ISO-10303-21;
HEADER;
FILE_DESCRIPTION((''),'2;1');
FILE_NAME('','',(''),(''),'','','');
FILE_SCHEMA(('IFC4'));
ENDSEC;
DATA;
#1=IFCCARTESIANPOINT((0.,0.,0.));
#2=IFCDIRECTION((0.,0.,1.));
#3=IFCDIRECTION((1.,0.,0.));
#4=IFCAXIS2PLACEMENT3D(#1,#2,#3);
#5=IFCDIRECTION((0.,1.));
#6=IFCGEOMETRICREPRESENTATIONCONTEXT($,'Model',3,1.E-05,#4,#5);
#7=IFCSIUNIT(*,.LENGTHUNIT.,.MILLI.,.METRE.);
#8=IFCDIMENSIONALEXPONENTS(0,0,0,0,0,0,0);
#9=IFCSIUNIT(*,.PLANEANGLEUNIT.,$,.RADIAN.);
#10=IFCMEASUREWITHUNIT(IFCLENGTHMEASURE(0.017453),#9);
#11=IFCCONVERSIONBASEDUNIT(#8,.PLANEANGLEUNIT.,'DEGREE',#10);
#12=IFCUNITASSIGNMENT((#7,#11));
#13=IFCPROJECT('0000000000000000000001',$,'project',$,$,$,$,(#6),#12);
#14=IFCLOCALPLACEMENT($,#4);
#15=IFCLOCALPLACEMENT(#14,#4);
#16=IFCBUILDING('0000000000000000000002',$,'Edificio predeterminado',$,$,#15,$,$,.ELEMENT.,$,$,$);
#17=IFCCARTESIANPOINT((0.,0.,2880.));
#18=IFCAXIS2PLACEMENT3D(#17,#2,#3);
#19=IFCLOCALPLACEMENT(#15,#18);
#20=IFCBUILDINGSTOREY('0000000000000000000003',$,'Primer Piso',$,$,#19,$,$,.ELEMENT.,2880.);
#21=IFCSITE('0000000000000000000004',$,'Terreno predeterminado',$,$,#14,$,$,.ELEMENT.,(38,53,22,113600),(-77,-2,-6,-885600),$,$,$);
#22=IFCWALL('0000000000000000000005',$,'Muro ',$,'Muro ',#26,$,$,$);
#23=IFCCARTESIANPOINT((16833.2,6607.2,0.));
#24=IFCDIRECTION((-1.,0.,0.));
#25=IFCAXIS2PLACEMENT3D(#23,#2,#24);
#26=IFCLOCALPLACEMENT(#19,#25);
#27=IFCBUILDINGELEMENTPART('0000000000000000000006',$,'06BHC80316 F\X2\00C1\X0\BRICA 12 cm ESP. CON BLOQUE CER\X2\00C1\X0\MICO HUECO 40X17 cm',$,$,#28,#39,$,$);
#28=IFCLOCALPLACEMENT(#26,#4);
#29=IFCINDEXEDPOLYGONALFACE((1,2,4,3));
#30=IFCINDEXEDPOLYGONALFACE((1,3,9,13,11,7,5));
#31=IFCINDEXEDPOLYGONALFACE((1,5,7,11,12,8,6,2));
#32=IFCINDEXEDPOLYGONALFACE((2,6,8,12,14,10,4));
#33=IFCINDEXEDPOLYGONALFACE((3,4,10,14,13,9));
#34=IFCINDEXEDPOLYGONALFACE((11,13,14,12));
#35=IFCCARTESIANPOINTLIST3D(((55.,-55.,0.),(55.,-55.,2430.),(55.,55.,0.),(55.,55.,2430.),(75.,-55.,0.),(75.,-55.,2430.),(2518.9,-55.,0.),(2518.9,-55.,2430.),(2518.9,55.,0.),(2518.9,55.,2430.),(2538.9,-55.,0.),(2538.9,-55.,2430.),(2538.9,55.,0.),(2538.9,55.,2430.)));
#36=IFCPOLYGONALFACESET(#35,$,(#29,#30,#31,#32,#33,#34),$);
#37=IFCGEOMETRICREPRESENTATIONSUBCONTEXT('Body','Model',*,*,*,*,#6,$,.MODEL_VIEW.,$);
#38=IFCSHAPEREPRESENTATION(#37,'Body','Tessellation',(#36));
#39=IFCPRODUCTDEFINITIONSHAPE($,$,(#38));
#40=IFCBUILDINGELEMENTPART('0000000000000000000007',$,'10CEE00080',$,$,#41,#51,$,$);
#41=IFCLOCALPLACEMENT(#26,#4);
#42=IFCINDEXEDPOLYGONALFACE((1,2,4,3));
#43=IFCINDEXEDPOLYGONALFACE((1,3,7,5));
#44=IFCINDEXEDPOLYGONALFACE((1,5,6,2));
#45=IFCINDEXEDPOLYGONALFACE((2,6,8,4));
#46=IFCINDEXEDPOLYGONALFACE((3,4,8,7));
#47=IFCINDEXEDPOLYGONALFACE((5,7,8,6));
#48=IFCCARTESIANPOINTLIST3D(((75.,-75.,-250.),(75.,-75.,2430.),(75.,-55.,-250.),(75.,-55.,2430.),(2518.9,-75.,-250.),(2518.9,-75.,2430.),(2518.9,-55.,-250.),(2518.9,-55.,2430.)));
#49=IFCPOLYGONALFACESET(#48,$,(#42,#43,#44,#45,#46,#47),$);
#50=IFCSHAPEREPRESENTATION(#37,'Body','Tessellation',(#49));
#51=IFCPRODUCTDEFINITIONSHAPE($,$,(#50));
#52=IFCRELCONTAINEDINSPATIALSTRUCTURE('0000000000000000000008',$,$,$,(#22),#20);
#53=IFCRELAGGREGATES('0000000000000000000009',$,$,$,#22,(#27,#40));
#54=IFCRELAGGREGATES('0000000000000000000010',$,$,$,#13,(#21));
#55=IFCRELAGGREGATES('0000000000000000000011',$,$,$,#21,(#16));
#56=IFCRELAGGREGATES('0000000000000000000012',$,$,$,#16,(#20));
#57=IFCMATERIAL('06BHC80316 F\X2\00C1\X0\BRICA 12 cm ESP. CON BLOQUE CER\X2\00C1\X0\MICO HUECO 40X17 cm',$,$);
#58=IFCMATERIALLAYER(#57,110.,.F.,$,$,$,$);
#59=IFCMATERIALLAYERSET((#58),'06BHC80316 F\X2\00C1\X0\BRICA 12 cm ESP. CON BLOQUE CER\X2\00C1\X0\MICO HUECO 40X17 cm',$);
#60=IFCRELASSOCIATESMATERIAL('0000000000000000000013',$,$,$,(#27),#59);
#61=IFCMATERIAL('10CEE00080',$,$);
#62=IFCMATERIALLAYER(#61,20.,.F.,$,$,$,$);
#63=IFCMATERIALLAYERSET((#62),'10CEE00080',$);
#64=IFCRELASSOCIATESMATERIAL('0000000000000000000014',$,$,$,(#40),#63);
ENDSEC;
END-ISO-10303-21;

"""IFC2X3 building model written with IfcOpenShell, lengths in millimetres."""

from ifc_helpers import new_model, entity, si_unit, converted_unit, direction, frame, origin_with_axes, place, context, subcontext, project, spatial, polyline, outline, extrude, material, layer, layer_set, layer_usage, element, aggregate, save


model = new_model("IFC2X3")

# Units and contexts
model_context = context("Model", 3, precision=1e-05, world=origin_with_axes(), true_north=direction((0.0, 1.0)))
body_context = subcontext(model_context, "Body", "Model", "MODEL_VIEW")
ifc_project = project(units=[si_unit("LENGTHUNIT", "METRE", prefix="MILLI"), converted_unit("PLANEANGLEUNIT", "DEGREE", entity("IfcLengthMeasure", 0.017453), si_unit("PLANEANGLEUNIT", "RADIAN"), dimensions=[0, 0, 0, 0, 0, 0, 0])], contexts=[model_context])

# Site, building, storey
site_placement = place(None, origin_with_axes())
site = spatial("IfcSite", under=ifc_project, at=site_placement, Name="Terreno predeterminado", CompositionType="ELEMENT", RefLatitude=(38, 53, 22, 113600), RefLongitude=(-77, -2, -6, -885600))
building_placement = place(site_placement, origin_with_axes())
building = spatial("IfcBuilding", under=site, at=building_placement, Name="Edificio predeterminado", CompositionType="ELEMENT")
storey_placement = place(building_placement, frame((0.0, 0.0, 2880.0), z_axis=(0.0, 0.0, 1.0), x_axis=(1.0, 0.0, 0.0)))
storey = spatial("IfcBuildingStorey", under=building, at=storey_placement, Name="Primer Piso", CompositionType="ELEMENT", Elevation=2880.0)

# Wall, building element parts
wall_1_placement = place(storey_placement, frame((16833.2, 6607.2, 0.0), z_axis=(0.0, 0.0, 1.0), x_axis=(-1.0, 0.0, 0.0)))
wall_1 = element("IfcWall", 1, at=wall_1_placement, inside=storey, Name="Muro ", ObjectType="Muro ")
ifc_material_1 = material(Name="06BHC80316 FÁBRICA 12 cm ESP. CON BLOQUE CERÁMICO HUECO 40X17 cm")
ifc_layer_1 = layer(ifc_material_1, 110.0, ventilated=False)
ifc_layer_set_1 = layer_set([ifc_layer_1], Name="06BHC80316 FÁBRICA 12 cm ESP. CON BLOQUE CERÁMICO HUECO 40X17 cm")
ifc_layer_usage_1 = layer_usage(ifc_layer_set_1, "AXIS2", "NEGATIVE", -55.0)
building_element_part_1_placement = place(wall_1_placement, origin_with_axes())
building_element_part_1 = element("IfcBuildingElementPart", 2, at=building_element_part_1_placement, material=ifc_layer_usage_1, Name="06BHC80316 FÁBRICA 12 cm ESP. CON BLOQUE CERÁMICO HUECO 40X17 cm", context=body_context, shape_type="SweptSolid", body=[
    extrude(outline(polyline([(2538.9, 55.0), (2538.9, -55.0), (2518.9, -55.0), (75.0, -55.0), (55.0, -55.0), (55.0, 55.0), (2518.9, 55.0), (2538.9, 55.0)])), origin_with_axes(), (0.0, 0.0, 1.0), 2430.0),
])
ifc_material_2 = material(Name="10CEE00080")
ifc_layer_2 = layer(ifc_material_2, 20.0, ventilated=False)
ifc_layer_set_2 = layer_set([ifc_layer_2], Name="10CEE00080")
ifc_layer_usage_2 = layer_usage(ifc_layer_set_2, "AXIS2", "NEGATIVE", 55.0)
building_element_part_2_placement = place(wall_1_placement, origin_with_axes())
building_element_part_2 = element("IfcBuildingElementPart", 3, at=building_element_part_2_placement, material=ifc_layer_usage_2, Name="10CEE00080", context=body_context, shape_type="SweptSolid", body=[
    extrude(outline(polyline([(2518.9, -55.0), (2518.9, -75.0), (75.0, -75.0), (75.0, -55.0), (2518.9, -55.0)])), frame((0.0, 0.0, -250.0), z_axis=(0.0, 0.0, 1.0), x_axis=(1.0, 0.0, 0.0)), (0.0, 0.0, 1.0), 2680.0),
])
aggregate(wall_1, [building_element_part_1, building_element_part_2])

save(model, "model.ifc")
